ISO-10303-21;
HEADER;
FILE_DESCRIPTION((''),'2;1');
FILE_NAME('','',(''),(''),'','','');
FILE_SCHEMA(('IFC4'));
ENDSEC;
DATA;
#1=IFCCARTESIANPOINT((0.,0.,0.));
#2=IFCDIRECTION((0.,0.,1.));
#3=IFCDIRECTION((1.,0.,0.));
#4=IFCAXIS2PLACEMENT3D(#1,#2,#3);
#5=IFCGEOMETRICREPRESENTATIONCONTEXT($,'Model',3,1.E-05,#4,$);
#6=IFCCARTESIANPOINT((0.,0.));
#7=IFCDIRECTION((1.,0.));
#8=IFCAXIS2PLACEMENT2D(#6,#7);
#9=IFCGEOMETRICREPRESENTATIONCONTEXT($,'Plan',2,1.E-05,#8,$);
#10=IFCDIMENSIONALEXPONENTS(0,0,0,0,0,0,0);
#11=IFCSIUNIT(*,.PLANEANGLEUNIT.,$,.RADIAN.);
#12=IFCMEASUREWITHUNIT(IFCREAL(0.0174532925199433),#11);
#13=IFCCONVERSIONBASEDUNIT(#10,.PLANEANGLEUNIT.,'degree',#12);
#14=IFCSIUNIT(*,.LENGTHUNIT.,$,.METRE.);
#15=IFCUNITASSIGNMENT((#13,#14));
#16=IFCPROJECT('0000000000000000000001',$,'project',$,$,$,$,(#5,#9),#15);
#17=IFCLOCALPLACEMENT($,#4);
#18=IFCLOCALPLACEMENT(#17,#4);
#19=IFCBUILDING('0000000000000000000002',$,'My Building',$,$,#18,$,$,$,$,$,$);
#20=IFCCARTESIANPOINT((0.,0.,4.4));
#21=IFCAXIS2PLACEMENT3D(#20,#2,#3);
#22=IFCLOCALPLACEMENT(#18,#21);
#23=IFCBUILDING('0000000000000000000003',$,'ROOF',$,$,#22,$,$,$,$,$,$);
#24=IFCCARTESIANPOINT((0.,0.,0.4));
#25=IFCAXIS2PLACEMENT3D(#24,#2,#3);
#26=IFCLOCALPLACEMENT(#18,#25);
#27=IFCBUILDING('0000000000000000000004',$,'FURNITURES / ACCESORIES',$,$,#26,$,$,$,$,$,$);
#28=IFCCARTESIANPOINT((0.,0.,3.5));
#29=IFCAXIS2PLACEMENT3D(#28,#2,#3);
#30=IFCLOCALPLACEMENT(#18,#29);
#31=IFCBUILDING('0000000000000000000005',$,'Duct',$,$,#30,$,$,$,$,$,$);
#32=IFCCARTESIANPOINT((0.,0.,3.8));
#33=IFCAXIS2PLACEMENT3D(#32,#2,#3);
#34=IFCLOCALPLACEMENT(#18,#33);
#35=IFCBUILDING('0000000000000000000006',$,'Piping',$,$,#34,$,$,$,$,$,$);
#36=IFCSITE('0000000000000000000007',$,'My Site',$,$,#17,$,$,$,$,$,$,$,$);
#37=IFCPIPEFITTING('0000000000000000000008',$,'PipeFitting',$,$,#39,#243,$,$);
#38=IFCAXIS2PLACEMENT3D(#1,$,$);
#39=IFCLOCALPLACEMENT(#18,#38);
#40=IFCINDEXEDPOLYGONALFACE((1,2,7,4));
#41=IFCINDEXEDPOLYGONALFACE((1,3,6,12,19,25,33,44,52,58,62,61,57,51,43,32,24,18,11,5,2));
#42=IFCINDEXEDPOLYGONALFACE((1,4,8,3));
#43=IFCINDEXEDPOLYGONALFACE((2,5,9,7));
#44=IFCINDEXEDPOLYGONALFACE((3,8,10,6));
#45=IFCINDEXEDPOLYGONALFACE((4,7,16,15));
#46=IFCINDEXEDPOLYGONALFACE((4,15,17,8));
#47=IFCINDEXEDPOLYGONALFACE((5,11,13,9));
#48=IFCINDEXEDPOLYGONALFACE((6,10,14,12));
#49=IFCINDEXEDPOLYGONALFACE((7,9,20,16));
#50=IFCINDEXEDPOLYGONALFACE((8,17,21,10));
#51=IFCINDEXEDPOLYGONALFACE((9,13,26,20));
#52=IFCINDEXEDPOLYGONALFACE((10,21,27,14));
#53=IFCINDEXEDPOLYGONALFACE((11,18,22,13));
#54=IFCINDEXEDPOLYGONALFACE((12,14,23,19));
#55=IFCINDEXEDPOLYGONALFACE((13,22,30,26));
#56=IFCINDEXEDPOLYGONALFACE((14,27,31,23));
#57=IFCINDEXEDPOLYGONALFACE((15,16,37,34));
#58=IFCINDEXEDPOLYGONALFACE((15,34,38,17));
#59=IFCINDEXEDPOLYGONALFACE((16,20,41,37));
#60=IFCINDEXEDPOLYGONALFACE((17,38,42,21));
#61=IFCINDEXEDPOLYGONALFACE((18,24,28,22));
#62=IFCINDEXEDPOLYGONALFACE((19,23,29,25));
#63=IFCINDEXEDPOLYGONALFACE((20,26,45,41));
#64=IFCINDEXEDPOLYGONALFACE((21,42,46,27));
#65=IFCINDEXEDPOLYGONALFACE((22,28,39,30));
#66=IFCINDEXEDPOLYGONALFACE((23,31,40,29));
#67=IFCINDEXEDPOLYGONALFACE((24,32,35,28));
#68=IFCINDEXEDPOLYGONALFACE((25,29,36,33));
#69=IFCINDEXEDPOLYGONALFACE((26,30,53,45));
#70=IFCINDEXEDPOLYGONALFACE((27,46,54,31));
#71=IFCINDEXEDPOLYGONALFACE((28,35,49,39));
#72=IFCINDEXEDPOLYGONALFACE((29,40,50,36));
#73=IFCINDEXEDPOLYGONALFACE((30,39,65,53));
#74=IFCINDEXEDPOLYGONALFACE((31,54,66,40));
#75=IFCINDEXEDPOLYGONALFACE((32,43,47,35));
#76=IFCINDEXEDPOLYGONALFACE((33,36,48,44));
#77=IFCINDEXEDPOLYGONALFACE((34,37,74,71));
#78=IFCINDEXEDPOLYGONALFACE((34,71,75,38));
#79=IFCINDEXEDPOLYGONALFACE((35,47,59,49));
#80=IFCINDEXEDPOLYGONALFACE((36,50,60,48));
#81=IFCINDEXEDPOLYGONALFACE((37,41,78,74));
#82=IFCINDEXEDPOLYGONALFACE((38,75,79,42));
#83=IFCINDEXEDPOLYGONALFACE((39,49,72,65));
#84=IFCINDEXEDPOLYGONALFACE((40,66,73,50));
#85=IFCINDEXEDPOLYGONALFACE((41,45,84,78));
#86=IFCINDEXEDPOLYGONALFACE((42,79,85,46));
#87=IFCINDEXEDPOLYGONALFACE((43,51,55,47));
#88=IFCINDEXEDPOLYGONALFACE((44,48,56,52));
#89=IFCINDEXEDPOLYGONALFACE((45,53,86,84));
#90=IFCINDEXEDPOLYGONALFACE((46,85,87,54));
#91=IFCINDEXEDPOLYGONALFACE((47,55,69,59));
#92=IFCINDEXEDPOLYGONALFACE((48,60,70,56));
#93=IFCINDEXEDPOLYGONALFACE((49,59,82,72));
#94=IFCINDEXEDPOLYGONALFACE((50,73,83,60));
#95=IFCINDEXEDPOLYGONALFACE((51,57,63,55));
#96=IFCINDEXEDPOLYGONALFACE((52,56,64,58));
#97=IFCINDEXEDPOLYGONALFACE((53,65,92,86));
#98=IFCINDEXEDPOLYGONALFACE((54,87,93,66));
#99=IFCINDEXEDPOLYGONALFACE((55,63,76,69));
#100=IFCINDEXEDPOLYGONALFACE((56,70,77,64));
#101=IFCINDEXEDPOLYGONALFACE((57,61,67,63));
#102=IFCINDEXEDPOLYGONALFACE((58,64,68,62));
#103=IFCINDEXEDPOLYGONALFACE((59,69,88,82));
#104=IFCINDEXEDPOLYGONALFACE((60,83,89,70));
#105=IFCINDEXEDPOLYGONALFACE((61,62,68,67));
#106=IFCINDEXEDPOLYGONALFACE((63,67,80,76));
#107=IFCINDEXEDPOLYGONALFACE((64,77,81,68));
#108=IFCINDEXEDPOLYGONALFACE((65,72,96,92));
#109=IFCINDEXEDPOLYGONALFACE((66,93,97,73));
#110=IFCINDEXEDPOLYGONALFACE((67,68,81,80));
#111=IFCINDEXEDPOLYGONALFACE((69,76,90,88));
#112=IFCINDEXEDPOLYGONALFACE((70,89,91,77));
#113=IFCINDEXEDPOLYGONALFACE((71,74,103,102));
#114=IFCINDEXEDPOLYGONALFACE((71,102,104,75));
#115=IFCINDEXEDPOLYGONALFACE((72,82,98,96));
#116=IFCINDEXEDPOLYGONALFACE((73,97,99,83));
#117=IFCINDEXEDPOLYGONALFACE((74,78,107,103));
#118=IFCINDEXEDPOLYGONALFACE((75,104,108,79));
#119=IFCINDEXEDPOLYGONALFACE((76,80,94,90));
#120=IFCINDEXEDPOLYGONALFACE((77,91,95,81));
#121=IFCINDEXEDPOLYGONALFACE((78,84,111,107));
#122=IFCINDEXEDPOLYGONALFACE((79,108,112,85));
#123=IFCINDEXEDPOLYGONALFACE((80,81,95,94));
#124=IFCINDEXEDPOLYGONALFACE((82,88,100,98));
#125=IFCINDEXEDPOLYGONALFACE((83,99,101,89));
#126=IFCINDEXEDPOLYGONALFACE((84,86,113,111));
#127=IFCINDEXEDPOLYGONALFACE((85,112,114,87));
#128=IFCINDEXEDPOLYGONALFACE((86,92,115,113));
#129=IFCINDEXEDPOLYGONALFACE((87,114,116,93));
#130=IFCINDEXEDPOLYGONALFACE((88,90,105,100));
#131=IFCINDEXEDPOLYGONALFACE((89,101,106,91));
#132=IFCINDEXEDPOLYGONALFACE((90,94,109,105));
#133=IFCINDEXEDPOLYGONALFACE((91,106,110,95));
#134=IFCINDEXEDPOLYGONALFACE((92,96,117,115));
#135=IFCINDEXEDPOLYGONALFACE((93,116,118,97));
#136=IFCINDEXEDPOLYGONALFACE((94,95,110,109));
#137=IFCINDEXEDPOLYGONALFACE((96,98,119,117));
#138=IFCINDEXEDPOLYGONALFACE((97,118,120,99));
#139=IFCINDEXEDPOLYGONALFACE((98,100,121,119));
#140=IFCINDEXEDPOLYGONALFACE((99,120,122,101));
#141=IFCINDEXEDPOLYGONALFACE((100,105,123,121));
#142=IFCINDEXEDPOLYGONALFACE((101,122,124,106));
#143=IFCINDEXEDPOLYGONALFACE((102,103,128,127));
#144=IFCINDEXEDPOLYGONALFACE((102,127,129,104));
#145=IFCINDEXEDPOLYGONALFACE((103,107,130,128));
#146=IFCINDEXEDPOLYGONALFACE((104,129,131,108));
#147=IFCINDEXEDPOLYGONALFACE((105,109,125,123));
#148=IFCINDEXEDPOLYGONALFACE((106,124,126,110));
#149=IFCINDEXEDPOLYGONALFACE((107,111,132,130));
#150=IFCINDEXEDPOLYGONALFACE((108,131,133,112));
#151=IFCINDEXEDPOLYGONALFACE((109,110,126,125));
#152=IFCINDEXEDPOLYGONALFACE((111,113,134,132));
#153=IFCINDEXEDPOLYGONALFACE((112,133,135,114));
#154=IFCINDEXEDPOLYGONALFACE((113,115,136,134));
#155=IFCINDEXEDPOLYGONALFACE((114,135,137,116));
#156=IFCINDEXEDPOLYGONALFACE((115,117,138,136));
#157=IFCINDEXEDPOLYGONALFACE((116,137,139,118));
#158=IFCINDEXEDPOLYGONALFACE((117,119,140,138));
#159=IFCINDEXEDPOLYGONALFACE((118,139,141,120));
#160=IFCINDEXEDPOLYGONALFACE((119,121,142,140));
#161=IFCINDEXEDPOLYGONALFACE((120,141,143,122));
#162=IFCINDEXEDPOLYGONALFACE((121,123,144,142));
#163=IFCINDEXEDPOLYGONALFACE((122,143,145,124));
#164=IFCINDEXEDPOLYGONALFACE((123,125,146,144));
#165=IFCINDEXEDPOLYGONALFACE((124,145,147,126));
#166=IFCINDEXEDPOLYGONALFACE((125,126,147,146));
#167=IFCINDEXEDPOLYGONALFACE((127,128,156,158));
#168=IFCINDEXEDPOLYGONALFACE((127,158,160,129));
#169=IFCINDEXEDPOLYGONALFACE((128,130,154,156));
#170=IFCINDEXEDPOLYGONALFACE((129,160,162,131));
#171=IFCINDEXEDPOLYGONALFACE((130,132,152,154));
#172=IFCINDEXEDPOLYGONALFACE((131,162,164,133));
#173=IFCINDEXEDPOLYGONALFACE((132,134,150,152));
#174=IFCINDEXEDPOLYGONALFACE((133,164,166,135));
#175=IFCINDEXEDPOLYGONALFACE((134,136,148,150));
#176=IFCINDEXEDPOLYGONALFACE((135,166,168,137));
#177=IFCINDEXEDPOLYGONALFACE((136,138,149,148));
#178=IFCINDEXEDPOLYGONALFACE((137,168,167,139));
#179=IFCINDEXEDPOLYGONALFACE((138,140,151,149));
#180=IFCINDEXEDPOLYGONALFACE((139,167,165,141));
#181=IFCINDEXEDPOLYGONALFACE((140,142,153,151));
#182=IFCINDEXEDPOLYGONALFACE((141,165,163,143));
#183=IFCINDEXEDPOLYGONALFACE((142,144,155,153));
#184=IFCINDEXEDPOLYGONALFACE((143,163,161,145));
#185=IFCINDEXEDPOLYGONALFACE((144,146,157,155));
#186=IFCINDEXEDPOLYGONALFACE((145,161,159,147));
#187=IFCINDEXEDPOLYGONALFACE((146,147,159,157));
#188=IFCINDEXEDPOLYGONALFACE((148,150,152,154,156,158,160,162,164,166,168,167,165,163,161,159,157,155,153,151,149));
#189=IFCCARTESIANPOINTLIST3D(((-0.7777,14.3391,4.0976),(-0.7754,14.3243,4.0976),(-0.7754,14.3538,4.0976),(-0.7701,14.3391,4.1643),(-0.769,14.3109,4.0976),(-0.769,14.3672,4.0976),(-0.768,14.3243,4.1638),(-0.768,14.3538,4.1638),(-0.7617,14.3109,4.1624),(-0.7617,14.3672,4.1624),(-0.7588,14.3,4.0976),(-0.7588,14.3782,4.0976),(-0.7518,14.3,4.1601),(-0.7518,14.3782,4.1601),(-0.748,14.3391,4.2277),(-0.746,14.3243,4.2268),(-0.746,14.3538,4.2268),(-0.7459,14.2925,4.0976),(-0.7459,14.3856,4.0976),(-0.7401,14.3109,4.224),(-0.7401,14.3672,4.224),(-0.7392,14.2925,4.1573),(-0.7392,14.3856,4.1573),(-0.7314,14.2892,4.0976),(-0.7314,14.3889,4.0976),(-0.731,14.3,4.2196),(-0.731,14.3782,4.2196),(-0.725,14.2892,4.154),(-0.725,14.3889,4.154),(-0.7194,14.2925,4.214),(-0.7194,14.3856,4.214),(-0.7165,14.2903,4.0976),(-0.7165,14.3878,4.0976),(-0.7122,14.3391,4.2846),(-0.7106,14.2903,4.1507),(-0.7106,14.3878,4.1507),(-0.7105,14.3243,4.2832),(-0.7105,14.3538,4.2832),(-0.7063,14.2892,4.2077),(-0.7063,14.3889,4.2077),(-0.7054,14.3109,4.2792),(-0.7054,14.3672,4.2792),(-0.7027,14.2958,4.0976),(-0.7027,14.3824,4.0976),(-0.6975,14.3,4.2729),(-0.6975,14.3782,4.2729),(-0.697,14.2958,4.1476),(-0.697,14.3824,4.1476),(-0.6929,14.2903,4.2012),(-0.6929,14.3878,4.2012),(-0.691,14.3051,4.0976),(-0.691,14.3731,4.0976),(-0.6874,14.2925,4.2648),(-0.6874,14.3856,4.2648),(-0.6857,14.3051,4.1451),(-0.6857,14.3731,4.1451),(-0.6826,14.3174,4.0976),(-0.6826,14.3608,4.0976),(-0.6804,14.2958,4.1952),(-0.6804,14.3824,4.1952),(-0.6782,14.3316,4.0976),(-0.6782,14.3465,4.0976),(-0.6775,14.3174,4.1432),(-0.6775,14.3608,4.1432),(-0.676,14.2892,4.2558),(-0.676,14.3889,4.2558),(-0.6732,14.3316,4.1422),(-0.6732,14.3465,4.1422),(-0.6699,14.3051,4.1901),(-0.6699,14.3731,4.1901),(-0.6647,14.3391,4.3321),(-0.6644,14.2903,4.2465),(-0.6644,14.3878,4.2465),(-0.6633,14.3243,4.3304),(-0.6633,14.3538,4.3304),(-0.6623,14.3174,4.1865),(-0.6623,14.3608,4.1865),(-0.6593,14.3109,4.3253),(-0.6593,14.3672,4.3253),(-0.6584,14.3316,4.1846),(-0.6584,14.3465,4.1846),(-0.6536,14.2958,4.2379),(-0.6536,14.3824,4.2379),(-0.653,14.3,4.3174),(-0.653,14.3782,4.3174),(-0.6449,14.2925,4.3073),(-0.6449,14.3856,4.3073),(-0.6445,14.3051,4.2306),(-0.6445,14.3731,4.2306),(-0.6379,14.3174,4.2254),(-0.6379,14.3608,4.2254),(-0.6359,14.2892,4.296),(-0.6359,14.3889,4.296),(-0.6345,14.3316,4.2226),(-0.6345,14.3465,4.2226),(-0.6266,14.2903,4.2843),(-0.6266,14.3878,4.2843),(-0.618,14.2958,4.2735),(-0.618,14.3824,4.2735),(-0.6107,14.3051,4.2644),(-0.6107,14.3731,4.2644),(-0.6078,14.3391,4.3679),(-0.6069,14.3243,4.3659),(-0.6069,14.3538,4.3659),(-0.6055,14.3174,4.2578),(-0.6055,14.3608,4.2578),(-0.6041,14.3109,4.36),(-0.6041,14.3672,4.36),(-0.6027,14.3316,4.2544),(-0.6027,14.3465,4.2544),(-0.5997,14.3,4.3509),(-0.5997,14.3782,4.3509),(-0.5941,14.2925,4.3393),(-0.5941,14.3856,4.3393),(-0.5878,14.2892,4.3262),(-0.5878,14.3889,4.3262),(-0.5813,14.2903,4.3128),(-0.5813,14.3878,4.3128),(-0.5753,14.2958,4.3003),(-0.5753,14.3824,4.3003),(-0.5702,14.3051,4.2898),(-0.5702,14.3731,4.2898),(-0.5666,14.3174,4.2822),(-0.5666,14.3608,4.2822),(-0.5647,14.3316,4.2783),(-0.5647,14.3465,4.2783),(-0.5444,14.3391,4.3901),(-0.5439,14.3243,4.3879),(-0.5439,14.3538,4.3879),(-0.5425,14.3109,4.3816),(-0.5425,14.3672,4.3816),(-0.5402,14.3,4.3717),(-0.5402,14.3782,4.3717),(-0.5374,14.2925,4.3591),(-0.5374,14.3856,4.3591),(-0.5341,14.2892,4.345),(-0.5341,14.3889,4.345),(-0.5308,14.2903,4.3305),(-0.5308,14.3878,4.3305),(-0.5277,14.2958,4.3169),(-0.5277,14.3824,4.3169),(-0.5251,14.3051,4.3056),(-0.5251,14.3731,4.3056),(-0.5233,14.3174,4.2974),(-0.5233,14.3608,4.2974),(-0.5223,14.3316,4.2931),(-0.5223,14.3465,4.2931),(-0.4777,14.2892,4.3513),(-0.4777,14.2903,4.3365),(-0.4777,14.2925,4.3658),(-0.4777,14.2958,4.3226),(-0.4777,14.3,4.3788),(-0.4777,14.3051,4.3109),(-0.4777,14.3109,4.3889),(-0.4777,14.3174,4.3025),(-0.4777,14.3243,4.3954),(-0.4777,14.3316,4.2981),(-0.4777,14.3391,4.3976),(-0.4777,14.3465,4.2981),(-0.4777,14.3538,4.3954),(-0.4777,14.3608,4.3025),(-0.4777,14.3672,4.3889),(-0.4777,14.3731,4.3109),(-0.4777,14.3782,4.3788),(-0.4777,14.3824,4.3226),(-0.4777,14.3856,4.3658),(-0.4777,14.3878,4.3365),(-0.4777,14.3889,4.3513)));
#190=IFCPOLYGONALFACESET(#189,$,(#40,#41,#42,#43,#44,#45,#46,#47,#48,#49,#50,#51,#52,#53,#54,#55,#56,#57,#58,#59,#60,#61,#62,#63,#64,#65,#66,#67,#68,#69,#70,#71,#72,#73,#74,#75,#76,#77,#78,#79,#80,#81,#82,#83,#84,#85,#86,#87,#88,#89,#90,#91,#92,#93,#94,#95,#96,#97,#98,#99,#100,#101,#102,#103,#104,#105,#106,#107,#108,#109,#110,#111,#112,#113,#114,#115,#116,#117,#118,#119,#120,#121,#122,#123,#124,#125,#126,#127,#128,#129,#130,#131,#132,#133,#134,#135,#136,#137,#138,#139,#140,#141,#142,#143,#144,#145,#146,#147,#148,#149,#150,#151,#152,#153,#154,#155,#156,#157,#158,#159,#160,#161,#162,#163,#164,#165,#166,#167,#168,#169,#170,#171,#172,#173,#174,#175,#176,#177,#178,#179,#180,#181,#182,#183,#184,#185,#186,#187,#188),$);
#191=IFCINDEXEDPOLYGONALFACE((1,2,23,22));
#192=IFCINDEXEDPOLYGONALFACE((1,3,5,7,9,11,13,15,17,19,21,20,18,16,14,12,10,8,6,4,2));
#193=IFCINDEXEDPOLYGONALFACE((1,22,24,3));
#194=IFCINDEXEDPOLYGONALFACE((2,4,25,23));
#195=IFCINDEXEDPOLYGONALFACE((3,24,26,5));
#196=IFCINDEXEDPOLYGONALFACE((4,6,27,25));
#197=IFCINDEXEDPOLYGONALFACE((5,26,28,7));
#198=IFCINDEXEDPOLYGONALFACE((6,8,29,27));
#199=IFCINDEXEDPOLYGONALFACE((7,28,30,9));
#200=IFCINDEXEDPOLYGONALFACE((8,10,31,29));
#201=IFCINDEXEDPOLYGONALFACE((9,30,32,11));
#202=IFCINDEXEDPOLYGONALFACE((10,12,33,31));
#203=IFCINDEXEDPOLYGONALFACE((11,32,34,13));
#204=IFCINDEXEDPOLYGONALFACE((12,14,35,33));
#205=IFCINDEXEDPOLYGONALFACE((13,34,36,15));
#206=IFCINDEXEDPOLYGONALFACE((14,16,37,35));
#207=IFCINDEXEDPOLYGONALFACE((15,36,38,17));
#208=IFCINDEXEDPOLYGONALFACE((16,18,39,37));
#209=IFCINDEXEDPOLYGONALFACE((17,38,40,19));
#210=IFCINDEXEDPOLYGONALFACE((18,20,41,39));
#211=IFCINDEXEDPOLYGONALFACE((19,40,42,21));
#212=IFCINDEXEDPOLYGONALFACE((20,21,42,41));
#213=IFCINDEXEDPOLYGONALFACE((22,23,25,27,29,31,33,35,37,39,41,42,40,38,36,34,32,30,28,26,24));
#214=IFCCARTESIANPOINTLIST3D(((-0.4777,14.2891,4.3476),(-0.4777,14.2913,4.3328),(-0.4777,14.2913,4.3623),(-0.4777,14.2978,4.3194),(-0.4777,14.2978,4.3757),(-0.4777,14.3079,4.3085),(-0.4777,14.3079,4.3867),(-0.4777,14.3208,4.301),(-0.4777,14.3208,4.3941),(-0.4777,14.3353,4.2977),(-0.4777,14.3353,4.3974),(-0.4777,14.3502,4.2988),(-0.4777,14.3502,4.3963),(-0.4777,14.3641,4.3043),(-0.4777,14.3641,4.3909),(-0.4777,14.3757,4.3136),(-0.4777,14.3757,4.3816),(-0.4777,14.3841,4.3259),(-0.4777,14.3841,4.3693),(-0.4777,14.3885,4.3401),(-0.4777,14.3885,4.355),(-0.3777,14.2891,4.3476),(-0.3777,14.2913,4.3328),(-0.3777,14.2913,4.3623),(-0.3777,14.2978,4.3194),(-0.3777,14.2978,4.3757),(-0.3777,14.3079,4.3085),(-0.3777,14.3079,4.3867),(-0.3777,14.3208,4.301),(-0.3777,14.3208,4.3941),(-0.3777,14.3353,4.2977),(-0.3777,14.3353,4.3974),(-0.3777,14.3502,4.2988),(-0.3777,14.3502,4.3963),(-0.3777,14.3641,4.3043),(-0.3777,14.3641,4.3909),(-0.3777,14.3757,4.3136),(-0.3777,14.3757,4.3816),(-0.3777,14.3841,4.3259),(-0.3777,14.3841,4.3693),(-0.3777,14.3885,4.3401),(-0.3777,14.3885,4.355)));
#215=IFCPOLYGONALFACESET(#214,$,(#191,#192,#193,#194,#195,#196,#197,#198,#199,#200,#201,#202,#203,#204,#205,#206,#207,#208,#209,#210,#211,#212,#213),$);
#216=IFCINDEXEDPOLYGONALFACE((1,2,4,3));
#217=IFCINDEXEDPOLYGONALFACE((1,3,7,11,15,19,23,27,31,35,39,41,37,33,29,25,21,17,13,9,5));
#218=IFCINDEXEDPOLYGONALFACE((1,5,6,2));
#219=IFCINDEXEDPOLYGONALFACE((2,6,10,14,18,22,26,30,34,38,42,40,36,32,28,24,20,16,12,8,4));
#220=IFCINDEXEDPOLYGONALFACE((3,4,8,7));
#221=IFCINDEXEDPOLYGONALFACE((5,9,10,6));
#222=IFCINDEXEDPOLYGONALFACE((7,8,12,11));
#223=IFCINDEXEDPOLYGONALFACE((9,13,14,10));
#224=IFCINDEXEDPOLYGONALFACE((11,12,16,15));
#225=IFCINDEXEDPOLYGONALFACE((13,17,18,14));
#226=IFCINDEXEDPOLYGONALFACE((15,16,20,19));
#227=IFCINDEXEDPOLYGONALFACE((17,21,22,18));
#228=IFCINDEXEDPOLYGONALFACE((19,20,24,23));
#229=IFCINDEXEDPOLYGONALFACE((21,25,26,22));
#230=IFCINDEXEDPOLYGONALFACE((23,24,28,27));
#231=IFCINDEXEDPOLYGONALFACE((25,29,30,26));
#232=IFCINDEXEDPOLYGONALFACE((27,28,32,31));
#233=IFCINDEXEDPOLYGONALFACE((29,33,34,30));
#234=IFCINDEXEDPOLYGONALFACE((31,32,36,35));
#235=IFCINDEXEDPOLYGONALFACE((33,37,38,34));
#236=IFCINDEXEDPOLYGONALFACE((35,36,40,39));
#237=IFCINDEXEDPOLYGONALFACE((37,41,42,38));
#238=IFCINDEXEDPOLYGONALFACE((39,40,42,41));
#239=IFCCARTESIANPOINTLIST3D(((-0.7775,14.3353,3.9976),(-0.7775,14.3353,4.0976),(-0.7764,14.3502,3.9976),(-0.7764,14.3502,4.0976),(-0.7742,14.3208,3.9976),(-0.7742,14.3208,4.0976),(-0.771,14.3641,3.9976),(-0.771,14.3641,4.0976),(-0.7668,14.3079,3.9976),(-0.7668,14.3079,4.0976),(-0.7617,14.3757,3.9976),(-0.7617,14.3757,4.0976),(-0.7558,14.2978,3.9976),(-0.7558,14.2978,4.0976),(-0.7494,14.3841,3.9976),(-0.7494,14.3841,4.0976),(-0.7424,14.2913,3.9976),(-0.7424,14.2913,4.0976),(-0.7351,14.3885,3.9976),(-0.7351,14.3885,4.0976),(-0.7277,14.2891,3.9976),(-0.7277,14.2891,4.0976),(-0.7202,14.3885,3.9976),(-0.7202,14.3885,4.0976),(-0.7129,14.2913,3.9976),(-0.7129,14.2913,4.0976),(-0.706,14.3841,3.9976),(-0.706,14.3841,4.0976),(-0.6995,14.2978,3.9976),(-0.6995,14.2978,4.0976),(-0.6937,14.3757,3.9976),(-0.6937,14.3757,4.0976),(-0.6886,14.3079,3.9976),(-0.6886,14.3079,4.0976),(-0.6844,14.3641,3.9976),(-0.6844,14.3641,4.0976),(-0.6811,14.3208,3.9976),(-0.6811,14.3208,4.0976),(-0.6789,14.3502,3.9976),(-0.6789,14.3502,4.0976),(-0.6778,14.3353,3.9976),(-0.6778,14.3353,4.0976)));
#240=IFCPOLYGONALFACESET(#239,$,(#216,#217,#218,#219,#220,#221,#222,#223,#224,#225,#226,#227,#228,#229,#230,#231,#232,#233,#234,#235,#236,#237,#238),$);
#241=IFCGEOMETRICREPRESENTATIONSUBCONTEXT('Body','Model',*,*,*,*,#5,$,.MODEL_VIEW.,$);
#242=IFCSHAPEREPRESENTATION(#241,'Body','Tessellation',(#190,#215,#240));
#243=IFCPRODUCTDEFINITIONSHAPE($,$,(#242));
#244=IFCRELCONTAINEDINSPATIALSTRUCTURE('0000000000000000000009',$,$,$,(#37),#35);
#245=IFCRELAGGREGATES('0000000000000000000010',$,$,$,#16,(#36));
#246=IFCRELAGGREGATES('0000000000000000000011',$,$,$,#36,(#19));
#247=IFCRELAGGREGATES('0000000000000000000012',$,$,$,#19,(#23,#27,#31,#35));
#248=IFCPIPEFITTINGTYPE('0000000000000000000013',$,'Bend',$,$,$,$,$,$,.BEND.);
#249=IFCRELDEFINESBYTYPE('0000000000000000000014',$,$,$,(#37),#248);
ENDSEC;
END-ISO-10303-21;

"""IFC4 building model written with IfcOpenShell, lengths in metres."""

from ifc_helpers import new_model, entity, si_unit, converted_unit, frame, origin_with_axes, origin_2d_with_axis, place, context, subcontext, project, spatial, circle, extrude, source, transform, mapped, type_object, type_shapes, element, save


model = new_model("IFC4")

# Units and contexts
model_context = context("Model", 3, precision=1e-05, world=origin_with_axes())
plan_context = context("Plan", 2, precision=1e-05, world=origin_2d_with_axis())
body_context_1 = subcontext(model_context, "Body", "Model", "MODEL_VIEW")
ifc_project = project(units=[converted_unit("PLANEANGLEUNIT", "degree", entity("IfcReal", 0.0174532925199433), si_unit("PLANEANGLEUNIT", "RADIAN"), dimensions=[0, 0, 0, 0, 0, 0, 0]), si_unit("LENGTHUNIT", "METRE")], contexts=[model_context, plan_context])

# Site, building
site_placement = place(None, origin_with_axes())
site = spatial("IfcSite", under=ifc_project, at=site_placement, Name="My Site")
building_1_placement = place(site_placement, origin_with_axes())
building_1 = spatial("IfcBuilding", under=site, at=building_1_placement, Name="My Building")

# Shared definitions
building_2_placement = place(building_1_placement, frame((0.0, 0.0, 4.4), z_axis=(0.0, 0.0, 1.0), x_axis=(1.0, 0.0, 0.0)))
building_2 = spatial("IfcBuilding", under=building_1, at=building_2_placement, Name="ROOF")

# Shared definitions
building_3_placement = place(building_1_placement, frame((0.0, 0.0, 0.4), z_axis=(0.0, 0.0, 1.0), x_axis=(1.0, 0.0, 0.0)))
building_3 = spatial("IfcBuilding", under=building_1, at=building_3_placement, Name="FURNITURES / ACCESORIES")

# Shared definitions
building_4_placement = place(building_1_placement, frame((0.0, 0.0, 3.5), z_axis=(0.0, 0.0, 1.0), x_axis=(1.0, 0.0, 0.0)))
building_4 = spatial("IfcBuilding", under=building_1, at=building_4_placement, Name="Duct")

# Shared definitions
building_5_placement = place(building_1_placement, frame((0.0, 0.0, 3.8), z_axis=(0.0, 0.0, 1.0), x_axis=(1.0, 0.0, 0.0)))
building_5 = spatial("IfcBuilding", under=building_1, at=building_5_placement, Name="Piping")

# Pipe fitting
pipe_fitting_type = type_object("IfcPipeFittingType", Name="Bend", PredefinedType="BEND")
shared_shape_1 = source(origin_with_axes(), body_context_1, "Body", "SolidModel", [
    entity("IfcSweptDiskSolid", entity("IfcIndexedPolyCurve", entity("IfcCartesianPointList3D", [[0.0, 0.0, 0.1], [0.0, -0.0732, 0.2768], [0.0, -0.25, 0.35]]), [entity("IfcArcIndex", [1, 2, 3])]), 0.05),
    extrude(circle(Radius=0.05), origin_with_axes(), (0.0, 0.0, 1.0), 0.1),
    extrude(circle(Radius=0.05), frame((0.0, -0.25, 0.35), z_axis=(0.0, -1.0, -0.000001), x_axis=(1.0, 0.0, 0.0)), (0.0, 0.0, 1.0), 0.1),
])
type_shapes(pipe_fitting_type, [shared_shape_1])
pipe_fitting_placement = place(building_5_placement, frame((-0.3777, 14.3391, 0.5476), z_axis=(-1.0, 0.0, 0.0), x_axis=(0.0, -1.0, 0.0)))
element("IfcPipeFitting", 1, at=pipe_fitting_placement, inside=building_5, type_object=pipe_fitting_type, Name="PipeFitting", context=body_context_1, shape_type="MappedRepresentation", body=[
    mapped(shared_shape_1, transform((0.0, 0.0, 0.0), x_axis=(1.0, 0.0, 0.0), y_axis=(0.0, 1.0, 0.0), z_axis=(0.0, 0.0, 1.0), scale=1.0)),
])

save(model, "model.ifc")
